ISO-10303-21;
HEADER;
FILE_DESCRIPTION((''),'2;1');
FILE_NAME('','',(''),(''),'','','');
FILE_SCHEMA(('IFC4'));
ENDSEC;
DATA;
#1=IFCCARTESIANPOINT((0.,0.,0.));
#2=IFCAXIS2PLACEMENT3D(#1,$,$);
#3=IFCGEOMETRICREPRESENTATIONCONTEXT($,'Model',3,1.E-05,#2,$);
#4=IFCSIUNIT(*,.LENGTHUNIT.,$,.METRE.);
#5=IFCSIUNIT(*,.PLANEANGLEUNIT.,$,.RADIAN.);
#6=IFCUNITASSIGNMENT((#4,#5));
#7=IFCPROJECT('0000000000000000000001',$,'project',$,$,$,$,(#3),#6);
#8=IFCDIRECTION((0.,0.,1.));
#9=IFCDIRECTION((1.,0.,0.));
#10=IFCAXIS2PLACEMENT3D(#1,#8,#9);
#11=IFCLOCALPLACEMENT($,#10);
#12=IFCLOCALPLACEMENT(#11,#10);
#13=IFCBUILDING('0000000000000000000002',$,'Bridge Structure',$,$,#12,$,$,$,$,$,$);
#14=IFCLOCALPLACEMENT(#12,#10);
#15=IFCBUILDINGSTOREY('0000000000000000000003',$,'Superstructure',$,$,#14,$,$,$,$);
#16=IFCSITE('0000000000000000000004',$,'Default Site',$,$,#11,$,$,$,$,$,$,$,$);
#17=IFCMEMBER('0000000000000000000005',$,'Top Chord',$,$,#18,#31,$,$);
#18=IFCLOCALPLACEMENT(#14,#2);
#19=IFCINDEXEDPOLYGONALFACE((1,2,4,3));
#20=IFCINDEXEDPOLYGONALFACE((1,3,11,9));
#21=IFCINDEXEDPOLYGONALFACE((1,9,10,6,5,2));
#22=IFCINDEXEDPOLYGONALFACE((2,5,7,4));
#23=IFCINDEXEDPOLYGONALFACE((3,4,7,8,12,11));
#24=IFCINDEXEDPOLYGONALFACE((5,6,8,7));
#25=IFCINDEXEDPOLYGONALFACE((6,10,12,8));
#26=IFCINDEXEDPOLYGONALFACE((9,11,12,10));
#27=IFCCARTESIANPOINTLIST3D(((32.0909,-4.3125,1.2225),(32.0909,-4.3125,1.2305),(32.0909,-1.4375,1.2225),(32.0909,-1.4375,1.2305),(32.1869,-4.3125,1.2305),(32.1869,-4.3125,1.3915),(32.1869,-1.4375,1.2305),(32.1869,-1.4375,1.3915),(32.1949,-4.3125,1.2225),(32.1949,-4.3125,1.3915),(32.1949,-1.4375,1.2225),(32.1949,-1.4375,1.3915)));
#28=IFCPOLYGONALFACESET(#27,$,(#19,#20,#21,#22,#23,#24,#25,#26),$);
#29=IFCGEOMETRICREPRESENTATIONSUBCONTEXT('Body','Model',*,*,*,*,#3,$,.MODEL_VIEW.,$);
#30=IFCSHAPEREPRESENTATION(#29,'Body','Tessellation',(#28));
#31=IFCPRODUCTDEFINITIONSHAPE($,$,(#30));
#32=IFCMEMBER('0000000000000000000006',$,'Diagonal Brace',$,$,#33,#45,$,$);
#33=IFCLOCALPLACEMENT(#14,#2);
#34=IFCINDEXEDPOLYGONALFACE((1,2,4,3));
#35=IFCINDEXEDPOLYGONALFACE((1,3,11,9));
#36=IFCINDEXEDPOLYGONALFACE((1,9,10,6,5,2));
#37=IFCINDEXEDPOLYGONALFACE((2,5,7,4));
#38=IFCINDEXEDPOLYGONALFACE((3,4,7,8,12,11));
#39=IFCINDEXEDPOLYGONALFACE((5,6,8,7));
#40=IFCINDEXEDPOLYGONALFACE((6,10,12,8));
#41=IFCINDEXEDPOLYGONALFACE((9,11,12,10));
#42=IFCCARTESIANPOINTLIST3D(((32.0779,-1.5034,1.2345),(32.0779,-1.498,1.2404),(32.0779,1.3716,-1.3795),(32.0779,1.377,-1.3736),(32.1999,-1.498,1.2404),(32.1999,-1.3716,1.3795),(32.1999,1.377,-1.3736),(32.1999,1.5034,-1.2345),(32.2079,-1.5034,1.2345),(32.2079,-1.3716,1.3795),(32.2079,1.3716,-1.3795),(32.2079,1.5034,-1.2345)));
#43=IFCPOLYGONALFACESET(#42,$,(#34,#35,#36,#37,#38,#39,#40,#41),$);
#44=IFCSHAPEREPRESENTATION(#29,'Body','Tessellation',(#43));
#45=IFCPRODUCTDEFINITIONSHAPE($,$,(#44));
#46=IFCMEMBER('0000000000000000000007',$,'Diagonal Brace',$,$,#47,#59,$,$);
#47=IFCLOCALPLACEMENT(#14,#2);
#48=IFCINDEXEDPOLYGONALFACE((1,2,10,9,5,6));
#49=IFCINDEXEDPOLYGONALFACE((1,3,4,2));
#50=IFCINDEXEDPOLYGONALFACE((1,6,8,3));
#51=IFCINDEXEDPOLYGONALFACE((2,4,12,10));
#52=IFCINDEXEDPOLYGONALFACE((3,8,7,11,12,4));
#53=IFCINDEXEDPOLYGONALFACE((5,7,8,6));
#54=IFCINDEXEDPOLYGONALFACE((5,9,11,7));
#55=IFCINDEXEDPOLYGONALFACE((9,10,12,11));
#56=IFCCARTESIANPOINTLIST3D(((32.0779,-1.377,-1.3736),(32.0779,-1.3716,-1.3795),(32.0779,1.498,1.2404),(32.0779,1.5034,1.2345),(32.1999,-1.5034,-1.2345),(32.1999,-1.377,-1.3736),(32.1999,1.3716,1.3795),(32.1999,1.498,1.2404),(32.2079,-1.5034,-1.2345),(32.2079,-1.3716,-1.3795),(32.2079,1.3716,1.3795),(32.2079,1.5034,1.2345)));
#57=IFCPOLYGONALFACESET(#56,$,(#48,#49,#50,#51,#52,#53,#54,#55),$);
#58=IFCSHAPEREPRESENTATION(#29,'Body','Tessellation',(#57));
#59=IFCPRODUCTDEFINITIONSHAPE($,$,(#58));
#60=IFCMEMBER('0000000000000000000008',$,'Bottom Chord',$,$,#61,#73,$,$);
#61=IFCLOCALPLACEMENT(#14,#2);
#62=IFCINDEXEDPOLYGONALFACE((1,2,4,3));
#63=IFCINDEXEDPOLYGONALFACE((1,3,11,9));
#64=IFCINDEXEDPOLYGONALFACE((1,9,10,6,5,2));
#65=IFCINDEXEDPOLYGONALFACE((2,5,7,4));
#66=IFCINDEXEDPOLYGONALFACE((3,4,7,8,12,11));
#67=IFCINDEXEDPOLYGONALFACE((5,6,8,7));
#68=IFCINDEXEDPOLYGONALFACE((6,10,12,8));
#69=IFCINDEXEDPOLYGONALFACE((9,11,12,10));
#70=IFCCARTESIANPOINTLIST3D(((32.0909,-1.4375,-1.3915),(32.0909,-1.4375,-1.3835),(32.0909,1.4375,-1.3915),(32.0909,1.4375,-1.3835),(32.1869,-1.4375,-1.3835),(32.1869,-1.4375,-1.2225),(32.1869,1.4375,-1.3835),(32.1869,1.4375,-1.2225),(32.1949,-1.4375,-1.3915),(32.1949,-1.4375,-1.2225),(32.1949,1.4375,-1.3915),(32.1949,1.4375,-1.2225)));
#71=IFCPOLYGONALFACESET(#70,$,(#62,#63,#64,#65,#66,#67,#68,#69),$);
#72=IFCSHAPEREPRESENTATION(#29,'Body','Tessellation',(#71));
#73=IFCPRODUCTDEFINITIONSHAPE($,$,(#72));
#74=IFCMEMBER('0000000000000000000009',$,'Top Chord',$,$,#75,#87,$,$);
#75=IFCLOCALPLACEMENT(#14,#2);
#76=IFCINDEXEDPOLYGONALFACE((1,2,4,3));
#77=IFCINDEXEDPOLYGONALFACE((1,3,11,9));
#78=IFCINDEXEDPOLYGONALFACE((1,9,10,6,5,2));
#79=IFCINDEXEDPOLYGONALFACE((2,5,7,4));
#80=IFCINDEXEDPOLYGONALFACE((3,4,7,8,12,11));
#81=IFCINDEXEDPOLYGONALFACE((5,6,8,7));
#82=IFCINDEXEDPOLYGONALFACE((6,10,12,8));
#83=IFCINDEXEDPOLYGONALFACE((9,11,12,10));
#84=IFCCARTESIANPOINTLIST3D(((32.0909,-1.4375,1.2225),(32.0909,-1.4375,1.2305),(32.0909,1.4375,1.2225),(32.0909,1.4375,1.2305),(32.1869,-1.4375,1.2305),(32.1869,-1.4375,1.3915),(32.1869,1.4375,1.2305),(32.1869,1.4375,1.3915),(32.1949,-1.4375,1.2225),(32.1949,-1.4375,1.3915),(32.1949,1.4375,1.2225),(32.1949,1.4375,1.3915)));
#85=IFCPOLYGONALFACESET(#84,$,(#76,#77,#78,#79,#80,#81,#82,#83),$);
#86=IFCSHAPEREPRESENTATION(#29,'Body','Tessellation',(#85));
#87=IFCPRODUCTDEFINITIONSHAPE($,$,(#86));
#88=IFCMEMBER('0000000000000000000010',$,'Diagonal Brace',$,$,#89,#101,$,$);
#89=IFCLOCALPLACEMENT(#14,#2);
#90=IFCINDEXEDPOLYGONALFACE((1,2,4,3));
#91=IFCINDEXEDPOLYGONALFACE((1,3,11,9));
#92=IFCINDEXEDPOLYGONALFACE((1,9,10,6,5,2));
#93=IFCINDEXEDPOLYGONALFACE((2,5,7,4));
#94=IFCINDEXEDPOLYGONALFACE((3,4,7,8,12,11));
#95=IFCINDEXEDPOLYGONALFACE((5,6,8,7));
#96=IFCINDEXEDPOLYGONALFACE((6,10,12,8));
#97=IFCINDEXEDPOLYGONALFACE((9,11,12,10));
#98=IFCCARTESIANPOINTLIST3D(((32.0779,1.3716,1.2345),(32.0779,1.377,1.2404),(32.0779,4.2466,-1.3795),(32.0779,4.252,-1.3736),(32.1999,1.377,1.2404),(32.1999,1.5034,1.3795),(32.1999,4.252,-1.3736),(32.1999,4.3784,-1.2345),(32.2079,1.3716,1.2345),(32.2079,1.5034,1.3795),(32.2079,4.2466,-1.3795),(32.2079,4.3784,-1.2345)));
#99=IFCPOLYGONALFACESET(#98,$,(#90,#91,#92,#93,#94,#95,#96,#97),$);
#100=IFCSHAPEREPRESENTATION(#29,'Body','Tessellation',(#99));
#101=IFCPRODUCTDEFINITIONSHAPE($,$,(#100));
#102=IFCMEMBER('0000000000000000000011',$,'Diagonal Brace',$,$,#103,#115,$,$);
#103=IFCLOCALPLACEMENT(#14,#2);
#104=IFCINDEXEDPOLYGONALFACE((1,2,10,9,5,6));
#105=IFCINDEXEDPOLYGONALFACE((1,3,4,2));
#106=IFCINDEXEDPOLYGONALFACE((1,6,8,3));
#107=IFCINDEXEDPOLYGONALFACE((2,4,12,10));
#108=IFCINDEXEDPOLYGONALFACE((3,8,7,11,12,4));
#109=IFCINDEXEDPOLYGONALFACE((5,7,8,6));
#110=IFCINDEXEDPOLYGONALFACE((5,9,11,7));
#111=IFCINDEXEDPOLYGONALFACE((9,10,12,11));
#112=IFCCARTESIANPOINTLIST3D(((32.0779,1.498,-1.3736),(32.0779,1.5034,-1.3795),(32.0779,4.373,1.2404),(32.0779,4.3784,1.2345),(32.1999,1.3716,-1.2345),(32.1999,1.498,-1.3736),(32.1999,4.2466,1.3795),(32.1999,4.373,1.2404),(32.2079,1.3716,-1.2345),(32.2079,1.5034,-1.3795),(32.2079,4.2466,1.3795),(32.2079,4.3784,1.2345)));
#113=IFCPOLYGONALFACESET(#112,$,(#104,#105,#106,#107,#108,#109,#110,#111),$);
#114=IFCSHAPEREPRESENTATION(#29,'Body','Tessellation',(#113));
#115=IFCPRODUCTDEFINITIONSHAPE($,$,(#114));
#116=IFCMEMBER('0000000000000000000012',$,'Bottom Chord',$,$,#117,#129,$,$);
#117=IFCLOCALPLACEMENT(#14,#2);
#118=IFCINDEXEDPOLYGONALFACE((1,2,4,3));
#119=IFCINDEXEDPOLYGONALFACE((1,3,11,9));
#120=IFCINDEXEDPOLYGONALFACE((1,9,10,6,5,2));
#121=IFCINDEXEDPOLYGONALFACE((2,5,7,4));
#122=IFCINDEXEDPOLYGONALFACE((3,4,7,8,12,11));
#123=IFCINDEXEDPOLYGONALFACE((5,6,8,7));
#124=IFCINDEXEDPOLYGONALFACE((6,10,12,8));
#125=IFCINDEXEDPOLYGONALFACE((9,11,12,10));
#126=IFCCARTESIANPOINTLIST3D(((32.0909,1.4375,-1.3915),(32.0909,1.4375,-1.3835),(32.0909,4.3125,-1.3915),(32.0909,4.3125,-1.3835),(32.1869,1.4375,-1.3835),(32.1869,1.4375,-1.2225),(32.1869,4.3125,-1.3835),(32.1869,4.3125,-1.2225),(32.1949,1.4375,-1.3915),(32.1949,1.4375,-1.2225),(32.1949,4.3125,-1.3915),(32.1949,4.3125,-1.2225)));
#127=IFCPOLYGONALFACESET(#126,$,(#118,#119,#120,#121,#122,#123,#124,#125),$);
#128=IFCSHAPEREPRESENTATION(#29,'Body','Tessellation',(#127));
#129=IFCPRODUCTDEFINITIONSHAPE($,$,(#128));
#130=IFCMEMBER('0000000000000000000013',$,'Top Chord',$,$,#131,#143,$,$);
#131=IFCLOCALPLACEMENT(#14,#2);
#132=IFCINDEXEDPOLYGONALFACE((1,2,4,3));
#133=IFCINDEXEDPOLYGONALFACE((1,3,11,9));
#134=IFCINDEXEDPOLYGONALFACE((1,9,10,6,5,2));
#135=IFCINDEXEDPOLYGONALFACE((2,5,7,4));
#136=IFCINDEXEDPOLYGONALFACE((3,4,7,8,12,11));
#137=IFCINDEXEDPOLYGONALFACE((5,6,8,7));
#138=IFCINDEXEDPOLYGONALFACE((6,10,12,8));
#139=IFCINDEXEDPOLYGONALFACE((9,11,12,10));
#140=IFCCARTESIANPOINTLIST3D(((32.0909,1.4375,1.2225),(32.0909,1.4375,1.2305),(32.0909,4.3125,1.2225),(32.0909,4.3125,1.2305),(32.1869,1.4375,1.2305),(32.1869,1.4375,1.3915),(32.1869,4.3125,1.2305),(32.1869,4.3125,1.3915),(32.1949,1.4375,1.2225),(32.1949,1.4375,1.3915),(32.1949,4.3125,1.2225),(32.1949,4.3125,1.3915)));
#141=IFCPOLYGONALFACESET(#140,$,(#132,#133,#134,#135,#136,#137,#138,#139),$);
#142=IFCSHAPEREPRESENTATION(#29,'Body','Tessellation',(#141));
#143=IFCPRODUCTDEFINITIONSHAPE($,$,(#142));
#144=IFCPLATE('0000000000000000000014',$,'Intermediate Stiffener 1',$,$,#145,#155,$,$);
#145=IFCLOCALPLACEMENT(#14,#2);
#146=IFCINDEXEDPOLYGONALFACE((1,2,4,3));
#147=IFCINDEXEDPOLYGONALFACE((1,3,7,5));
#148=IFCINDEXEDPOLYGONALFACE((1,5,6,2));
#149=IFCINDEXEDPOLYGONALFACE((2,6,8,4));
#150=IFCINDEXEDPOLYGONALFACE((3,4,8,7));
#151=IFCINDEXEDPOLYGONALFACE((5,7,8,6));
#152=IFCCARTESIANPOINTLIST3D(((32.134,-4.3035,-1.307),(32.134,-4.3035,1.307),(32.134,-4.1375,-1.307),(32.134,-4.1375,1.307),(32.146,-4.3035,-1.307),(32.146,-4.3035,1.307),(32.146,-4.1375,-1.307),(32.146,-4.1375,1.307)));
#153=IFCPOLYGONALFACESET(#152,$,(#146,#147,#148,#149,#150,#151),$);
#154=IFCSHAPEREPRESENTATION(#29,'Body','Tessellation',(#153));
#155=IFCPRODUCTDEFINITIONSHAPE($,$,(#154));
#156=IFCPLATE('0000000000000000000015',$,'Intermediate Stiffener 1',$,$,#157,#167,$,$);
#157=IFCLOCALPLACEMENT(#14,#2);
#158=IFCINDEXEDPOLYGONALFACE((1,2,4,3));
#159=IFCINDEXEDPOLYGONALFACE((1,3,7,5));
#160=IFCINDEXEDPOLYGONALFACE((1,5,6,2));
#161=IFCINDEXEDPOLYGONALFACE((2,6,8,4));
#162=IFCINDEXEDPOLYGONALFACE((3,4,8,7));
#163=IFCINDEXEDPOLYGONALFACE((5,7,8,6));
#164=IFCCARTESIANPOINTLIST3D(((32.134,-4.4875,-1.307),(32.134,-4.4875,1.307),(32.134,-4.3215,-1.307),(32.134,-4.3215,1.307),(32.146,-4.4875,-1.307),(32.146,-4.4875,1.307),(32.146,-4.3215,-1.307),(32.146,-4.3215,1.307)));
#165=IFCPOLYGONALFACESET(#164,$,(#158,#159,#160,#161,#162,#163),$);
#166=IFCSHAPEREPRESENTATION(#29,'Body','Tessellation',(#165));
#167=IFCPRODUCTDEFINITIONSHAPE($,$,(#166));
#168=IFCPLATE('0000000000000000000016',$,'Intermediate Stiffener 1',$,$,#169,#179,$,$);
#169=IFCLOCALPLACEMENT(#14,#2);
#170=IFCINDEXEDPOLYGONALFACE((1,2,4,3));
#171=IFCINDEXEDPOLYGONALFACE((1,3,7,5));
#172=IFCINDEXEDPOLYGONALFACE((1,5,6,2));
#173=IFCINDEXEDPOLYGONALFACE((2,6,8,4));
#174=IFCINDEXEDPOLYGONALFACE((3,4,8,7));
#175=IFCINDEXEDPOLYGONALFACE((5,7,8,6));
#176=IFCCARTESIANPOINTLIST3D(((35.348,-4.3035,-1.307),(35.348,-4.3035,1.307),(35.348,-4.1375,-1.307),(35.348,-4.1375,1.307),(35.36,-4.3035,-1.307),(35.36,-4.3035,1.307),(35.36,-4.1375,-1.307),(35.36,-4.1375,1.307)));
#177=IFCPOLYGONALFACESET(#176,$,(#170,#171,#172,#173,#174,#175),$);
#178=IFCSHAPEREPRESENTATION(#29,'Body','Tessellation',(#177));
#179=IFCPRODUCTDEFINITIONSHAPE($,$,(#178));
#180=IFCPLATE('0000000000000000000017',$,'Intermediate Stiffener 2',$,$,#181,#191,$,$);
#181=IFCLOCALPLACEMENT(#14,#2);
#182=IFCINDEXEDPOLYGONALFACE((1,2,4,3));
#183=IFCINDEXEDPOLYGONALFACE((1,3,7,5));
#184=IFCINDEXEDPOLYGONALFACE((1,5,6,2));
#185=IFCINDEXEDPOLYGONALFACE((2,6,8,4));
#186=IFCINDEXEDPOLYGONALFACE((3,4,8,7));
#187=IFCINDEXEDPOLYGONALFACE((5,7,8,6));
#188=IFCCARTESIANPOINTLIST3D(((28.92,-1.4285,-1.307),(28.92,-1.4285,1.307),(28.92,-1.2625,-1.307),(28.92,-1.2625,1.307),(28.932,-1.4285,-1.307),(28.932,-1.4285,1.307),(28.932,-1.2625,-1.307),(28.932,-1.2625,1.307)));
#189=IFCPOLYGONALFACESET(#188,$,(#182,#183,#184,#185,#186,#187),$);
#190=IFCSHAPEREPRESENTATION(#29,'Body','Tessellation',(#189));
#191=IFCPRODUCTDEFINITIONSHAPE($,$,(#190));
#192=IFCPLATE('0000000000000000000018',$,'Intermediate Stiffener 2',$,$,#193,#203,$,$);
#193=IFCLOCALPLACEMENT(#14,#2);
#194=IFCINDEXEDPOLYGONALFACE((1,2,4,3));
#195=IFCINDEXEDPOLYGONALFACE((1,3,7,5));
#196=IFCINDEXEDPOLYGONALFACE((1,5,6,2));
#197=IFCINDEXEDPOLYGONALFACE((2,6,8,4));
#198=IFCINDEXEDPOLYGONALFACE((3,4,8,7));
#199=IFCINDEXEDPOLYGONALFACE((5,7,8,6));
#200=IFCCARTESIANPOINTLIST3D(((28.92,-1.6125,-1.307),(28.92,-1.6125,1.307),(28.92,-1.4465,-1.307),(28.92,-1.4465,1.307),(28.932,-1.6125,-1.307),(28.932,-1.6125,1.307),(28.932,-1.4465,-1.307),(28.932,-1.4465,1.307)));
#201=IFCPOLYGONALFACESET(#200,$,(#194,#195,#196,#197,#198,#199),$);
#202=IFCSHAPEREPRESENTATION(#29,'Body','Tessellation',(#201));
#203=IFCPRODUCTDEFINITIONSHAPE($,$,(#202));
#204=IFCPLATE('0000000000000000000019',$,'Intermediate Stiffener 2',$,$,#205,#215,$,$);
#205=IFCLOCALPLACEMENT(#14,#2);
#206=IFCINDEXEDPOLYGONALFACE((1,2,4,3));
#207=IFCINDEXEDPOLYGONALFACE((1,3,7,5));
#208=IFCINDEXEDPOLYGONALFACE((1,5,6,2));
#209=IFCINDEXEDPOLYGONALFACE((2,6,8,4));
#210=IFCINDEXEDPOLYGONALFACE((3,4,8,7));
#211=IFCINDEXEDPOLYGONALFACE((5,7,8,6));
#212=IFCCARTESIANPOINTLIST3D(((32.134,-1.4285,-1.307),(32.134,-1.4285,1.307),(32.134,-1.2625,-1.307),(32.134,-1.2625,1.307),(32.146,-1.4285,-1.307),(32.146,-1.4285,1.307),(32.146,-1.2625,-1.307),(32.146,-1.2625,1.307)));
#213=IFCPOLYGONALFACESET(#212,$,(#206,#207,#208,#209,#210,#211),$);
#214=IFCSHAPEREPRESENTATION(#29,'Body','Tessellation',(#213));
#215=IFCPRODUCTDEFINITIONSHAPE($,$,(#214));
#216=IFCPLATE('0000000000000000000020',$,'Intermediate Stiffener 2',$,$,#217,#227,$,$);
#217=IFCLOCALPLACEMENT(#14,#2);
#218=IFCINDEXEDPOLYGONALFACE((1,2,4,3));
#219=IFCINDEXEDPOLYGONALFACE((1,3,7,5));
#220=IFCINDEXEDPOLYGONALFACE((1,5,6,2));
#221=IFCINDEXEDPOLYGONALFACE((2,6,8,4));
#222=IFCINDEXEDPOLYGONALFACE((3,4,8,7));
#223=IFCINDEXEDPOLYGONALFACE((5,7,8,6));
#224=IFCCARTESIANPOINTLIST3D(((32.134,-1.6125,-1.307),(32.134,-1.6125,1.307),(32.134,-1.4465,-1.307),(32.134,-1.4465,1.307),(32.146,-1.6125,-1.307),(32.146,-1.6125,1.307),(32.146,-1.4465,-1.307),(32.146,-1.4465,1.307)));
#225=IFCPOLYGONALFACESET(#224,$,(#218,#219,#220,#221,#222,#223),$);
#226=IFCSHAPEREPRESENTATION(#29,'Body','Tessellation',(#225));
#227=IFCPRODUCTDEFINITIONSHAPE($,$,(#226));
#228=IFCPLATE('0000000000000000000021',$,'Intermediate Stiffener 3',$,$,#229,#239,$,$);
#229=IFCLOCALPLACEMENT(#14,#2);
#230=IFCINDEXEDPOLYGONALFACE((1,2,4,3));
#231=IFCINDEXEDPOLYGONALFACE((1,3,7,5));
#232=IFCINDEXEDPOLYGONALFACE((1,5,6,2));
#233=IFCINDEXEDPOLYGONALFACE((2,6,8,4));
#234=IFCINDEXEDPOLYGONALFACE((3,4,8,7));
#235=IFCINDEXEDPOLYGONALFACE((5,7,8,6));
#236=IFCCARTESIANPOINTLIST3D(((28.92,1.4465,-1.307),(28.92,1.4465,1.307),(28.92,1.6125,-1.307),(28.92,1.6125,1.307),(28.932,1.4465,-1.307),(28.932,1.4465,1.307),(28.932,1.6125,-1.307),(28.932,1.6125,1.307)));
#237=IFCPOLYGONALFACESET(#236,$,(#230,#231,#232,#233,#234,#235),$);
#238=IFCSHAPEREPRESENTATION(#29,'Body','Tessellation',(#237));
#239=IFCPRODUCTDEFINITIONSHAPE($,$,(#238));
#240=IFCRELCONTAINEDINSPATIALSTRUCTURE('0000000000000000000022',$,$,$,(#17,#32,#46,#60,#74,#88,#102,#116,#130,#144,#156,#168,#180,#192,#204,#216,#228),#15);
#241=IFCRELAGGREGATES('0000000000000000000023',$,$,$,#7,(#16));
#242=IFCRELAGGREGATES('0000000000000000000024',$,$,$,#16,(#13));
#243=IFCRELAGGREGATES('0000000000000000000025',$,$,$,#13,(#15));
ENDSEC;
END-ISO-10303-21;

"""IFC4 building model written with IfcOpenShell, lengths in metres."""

from ifc_helpers import new_model, si_unit, frame, origin, origin_with_axes, origin_2d_with_axis, place, context, subcontext, project, spatial, rectangle, l_section, extrude, element, save


model = new_model("IFC4")

# Units and contexts
model_context = context("Model", 3, precision=1e-05, world=origin())
body_context = subcontext(model_context, "Body", "Model", "MODEL_VIEW")
ifc_project = project(units=[si_unit("LENGTHUNIT", "METRE"), si_unit("PLANEANGLEUNIT", "RADIAN")], contexts=[model_context])

# Site, building, storey
site_placement = place(None, origin_with_axes())
site = spatial("IfcSite", under=ifc_project, at=site_placement, Name="Default Site")
building_placement = place(site_placement, origin_with_axes())
building = spatial("IfcBuilding", under=site, at=building_placement, Name="Bridge Structure")
storey_placement = place(building_placement, origin_with_axes())
storey = spatial("IfcBuildingStorey", under=building, at=storey_placement, Name="Superstructure")

# Members
for number, where, z_axis, x_axis, name in (
    (1, (32.1429, -4.3125, 1.307), (0.0, 1.0, 0.0), (-1.0, 0.0, 0.0), "Top Chord"),
):
    element("IfcMember", number, at=place(storey_placement, frame(where, z_axis=z_axis, x_axis=x_axis)), inside=storey, Name=name, context=body_context, shape_type="SweptSolid", body=[
        extrude(l_section(Depth=0.169, Width=0.104, Thickness=0.008, at=origin_2d_with_axis()), origin_with_axes(), (0.0, 0.0, 1.0), 2.875),
    ])
for number, where, z_axis, x_axis, name in (
    (2, (32.1429, -1.4375, 1.307), (0.0, 0.739893, -0.672724), (-1.0, 0.0, 0.0), "Diagonal Brace"),
    (3, (32.1429, -1.4375, -1.307), (0.0, 0.739893, 0.672724), (-1.0, 0.0, 0.0), "Diagonal Brace"),
):
    element("IfcMember", number, at=place(storey_placement, frame(where, z_axis=z_axis, x_axis=x_axis)), inside=storey, Name=name, context=body_context, shape_type="SweptSolid", body=[
        extrude(l_section(Depth=0.196, Width=0.13, Thickness=0.008, at=origin_2d_with_axis()), origin_with_axes(), (0.0, 0.0, 1.0), 3.8857),
    ])
for number, where, z_axis, x_axis, name in (
    (4, (32.1429, -1.4375, -1.307), (0.0, 1.0, 0.0), (-1.0, 0.0, 0.0), "Bottom Chord"),
    (5, (32.1429, -1.4375, 1.307), (0.0, 1.0, 0.0), (-1.0, 0.0, 0.0), "Top Chord"),
):
    element("IfcMember", number, at=place(storey_placement, frame(where, z_axis=z_axis, x_axis=x_axis)), inside=storey, Name=name, context=body_context, shape_type="SweptSolid", body=[
        extrude(l_section(Depth=0.169, Width=0.104, Thickness=0.008, at=origin_2d_with_axis()), origin_with_axes(), (0.0, 0.0, 1.0), 2.875),
    ])
for number, where, z_axis, x_axis, name in (
    (6, (32.1429, 1.4375, 1.307), (0.0, 0.739893, -0.672724), (-1.0, 0.0, 0.0), "Diagonal Brace"),
    (7, (32.1429, 1.4375, -1.307), (0.0, 0.739893, 0.672724), (-1.0, 0.0, 0.0), "Diagonal Brace"),
):
    element("IfcMember", number, at=place(storey_placement, frame(where, z_axis=z_axis, x_axis=x_axis)), inside=storey, Name=name, context=body_context, shape_type="SweptSolid", body=[
        extrude(l_section(Depth=0.196, Width=0.13, Thickness=0.008, at=origin_2d_with_axis()), origin_with_axes(), (0.0, 0.0, 1.0), 3.8857),
    ])
for number, where, z_axis, x_axis, name in (
    (8, (32.1429, 1.4375, -1.307), (0.0, 1.0, 0.0), (-1.0, 0.0, 0.0), "Bottom Chord"),
    (9, (32.1429, 1.4375, 1.307), (0.0, 1.0, 0.0), (-1.0, 0.0, 0.0), "Top Chord"),
):
    element("IfcMember", number, at=place(storey_placement, frame(where, z_axis=z_axis, x_axis=x_axis)), inside=storey, Name=name, context=body_context, shape_type="SweptSolid", body=[
        extrude(l_section(Depth=0.169, Width=0.104, Thickness=0.008, at=origin_2d_with_axis()), origin_with_axes(), (0.0, 0.0, 1.0), 2.875),
    ])

# Plates
for number, where, z_axis, x_axis, name in (
    (10, (32.14, -4.2205, -1.307), (0.0, 0.0, 1.0), (1.0, 0.0, 0.0), "Intermediate Stiffener 1"),
    (11, (32.14, -4.4045, -1.307), (0.0, 0.0, 1.0), (1.0, 0.0, 0.0), "Intermediate Stiffener 1"),
    (12, (35.354, -4.2205, -1.307), (0.0, 0.0, 1.0), (1.0, 0.0, 0.0), "Intermediate Stiffener 1"),
    (13, (28.926, -1.3455, -1.307), (0.0, 0.0, 1.0), (1.0, 0.0, 0.0), "Intermediate Stiffener 2"),
    (14, (28.926, -1.5295, -1.307), (0.0, 0.0, 1.0), (1.0, 0.0, 0.0), "Intermediate Stiffener 2"),
    (15, (32.14, -1.3455, -1.307), (0.0, 0.0, 1.0), (1.0, 0.0, 0.0), "Intermediate Stiffener 2"),
    (16, (32.14, -1.5295, -1.307), (0.0, 0.0, 1.0), (1.0, 0.0, 0.0), "Intermediate Stiffener 2"),
    (17, (28.926, 1.5295, -1.307), (0.0, 0.0, 1.0), (1.0, 0.0, 0.0), "Intermediate Stiffener 3"),
):
    element("IfcPlate", number, at=place(storey_placement, frame(where, z_axis=z_axis, x_axis=x_axis)), inside=storey, Name=name, context=body_context, shape_type="SweptSolid", body=[
        extrude(rectangle(XDim=0.012, YDim=0.166, at=origin_2d_with_axis()), origin_with_axes(), (0.0, 0.0, 1.0), 2.614),
    ])

save(model, "model.ifc")
